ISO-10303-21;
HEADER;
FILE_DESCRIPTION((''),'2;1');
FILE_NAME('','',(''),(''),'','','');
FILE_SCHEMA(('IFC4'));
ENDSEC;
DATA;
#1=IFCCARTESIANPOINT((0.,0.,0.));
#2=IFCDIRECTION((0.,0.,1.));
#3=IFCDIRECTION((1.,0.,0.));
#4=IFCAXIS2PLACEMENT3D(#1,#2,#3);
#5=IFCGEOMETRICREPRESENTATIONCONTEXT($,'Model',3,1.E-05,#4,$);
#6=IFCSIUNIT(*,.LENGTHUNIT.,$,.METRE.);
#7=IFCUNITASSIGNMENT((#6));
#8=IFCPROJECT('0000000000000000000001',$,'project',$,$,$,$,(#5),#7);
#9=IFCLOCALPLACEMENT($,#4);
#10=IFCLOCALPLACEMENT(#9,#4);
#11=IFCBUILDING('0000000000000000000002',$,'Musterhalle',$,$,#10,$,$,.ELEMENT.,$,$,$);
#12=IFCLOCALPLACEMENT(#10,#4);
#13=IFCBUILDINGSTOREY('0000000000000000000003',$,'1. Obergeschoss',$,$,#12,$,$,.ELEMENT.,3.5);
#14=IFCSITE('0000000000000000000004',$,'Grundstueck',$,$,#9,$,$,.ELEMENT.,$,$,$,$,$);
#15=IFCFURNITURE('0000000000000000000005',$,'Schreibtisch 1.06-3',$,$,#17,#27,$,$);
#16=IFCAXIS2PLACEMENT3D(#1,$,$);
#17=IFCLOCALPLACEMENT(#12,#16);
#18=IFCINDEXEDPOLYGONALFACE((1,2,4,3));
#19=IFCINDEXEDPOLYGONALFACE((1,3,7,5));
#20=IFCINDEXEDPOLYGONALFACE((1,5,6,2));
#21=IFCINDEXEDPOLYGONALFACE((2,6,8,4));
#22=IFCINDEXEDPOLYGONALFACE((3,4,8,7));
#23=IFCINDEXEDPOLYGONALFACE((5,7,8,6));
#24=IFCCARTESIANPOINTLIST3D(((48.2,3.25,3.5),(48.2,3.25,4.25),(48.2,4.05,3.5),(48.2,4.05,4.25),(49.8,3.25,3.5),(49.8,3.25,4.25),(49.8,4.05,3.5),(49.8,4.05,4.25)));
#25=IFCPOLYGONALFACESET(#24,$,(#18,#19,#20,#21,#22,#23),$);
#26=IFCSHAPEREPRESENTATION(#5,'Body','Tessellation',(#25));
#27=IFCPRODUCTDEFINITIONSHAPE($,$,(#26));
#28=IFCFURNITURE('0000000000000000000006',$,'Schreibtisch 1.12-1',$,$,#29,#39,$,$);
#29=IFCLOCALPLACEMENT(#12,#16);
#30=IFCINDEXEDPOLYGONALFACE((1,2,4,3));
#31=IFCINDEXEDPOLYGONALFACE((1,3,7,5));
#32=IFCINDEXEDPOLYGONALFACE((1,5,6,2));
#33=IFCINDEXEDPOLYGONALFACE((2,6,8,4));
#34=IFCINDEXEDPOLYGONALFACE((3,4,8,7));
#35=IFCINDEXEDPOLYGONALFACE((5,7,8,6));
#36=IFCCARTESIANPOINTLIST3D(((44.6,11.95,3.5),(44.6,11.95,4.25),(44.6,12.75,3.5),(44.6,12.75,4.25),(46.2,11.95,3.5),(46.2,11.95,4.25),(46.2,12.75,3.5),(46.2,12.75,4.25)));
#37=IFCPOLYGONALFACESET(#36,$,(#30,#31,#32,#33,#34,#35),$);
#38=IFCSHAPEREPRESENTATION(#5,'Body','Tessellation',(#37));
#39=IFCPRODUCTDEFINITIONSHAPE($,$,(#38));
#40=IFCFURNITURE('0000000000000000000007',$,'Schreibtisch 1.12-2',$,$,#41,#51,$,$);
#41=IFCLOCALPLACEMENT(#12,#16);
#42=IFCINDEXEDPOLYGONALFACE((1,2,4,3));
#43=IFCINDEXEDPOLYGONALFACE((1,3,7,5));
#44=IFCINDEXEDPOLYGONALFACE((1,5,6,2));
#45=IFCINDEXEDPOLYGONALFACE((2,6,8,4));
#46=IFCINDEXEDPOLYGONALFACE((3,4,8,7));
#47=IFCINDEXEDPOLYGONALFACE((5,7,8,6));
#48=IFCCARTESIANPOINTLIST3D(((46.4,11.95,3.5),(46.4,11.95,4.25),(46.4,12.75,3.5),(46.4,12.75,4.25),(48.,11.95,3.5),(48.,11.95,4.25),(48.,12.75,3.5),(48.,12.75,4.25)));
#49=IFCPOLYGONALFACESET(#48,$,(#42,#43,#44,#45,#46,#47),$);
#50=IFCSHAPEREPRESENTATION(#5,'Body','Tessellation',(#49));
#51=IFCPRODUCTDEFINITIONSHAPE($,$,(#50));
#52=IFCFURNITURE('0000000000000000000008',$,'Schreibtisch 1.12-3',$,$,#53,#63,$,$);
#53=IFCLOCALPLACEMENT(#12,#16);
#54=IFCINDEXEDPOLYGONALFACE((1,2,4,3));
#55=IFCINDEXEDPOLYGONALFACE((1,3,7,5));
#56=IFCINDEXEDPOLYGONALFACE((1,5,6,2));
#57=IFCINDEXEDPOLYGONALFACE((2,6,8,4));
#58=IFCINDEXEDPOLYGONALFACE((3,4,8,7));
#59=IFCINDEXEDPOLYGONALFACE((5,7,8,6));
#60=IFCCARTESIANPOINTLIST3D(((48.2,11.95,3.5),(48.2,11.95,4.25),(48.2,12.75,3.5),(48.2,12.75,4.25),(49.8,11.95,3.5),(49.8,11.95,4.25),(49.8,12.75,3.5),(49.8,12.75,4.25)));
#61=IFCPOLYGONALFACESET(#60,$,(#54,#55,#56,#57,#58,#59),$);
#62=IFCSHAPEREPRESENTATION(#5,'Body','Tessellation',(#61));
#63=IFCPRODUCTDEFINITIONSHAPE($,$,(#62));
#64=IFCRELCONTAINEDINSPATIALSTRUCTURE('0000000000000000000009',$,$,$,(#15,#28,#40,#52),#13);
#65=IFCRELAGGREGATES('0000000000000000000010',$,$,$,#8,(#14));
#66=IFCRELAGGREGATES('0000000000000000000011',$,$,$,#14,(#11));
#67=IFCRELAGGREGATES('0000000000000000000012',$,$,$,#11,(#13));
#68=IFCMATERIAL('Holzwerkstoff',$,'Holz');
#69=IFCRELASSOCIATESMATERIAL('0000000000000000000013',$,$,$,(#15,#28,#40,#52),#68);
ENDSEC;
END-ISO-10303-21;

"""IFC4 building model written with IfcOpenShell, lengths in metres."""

from ifc_helpers import new_model, si_unit, frame, origin_with_axes, origin_2d, place, context, project, spatial, rectangle, extrude, material, element, save


model = new_model("IFC4")

# Units and contexts
model_context = context("Model", 3, precision=1e-05, world=origin_with_axes())
ifc_project = project(units=[si_unit("LENGTHUNIT", "METRE")], contexts=[model_context])

# Site, building, storey
site_placement = place(None, origin_with_axes())
site = spatial("IfcSite", under=ifc_project, at=site_placement, Name="Grundstueck", CompositionType="ELEMENT")
building_placement = place(site_placement, origin_with_axes())
building = spatial("IfcBuilding", under=site, at=building_placement, Name="Musterhalle", CompositionType="ELEMENT")
storey_placement = place(building_placement, origin_with_axes())
storey = spatial("IfcBuildingStorey", under=building, at=storey_placement, Name="1. Obergeschoss", CompositionType="ELEMENT", Elevation=3.5)

# Shared definitions
placement = place(storey_placement, origin_with_axes())

# Shared definitions
ifc_material_1 = material(Name="Holzwerkstoff", Category="Holz")

# Furniture
element("IfcFurniture", 1, at=placement, inside=storey, material=ifc_material_1, Name="Schreibtisch 1.06-3", context=model_context, shape_type="SweptSolid", body=[
    extrude(rectangle(XDim=1.6, YDim=0.8, at=origin_2d()), frame((49.0, 3.65, 3.5), z_axis=(0.0, 0.0, 1.0), x_axis=(1.0, 0.0, 0.0)), (0.0, 0.0, 1.0), 0.75),
])
element("IfcFurniture", 2, at=placement, inside=storey, material=ifc_material_1, Name="Schreibtisch 1.12-1", context=model_context, shape_type="SweptSolid", body=[
    extrude(rectangle(XDim=1.6, YDim=0.8, at=origin_2d()), frame((45.4, 12.35, 3.5), z_axis=(0.0, 0.0, 1.0), x_axis=(1.0, 0.0, 0.0)), (0.0, 0.0, 1.0), 0.75),
])
element("IfcFurniture", 3, at=placement, inside=storey, material=ifc_material_1, Name="Schreibtisch 1.12-2", context=model_context, shape_type="SweptSolid", body=[
    extrude(rectangle(XDim=1.6, YDim=0.8, at=origin_2d()), frame((47.2, 12.35, 3.5), z_axis=(0.0, 0.0, 1.0), x_axis=(1.0, 0.0, 0.0)), (0.0, 0.0, 1.0), 0.75),
])
element("IfcFurniture", 4, at=placement, inside=storey, material=ifc_material_1, Name="Schreibtisch 1.12-3", context=model_context, shape_type="SweptSolid", body=[
    extrude(rectangle(XDim=1.6, YDim=0.8, at=origin_2d()), frame((49.0, 12.35, 3.5), z_axis=(0.0, 0.0, 1.0), x_axis=(1.0, 0.0, 0.0)), (0.0, 0.0, 1.0), 0.75),
])

save(model, "model.ifc")
